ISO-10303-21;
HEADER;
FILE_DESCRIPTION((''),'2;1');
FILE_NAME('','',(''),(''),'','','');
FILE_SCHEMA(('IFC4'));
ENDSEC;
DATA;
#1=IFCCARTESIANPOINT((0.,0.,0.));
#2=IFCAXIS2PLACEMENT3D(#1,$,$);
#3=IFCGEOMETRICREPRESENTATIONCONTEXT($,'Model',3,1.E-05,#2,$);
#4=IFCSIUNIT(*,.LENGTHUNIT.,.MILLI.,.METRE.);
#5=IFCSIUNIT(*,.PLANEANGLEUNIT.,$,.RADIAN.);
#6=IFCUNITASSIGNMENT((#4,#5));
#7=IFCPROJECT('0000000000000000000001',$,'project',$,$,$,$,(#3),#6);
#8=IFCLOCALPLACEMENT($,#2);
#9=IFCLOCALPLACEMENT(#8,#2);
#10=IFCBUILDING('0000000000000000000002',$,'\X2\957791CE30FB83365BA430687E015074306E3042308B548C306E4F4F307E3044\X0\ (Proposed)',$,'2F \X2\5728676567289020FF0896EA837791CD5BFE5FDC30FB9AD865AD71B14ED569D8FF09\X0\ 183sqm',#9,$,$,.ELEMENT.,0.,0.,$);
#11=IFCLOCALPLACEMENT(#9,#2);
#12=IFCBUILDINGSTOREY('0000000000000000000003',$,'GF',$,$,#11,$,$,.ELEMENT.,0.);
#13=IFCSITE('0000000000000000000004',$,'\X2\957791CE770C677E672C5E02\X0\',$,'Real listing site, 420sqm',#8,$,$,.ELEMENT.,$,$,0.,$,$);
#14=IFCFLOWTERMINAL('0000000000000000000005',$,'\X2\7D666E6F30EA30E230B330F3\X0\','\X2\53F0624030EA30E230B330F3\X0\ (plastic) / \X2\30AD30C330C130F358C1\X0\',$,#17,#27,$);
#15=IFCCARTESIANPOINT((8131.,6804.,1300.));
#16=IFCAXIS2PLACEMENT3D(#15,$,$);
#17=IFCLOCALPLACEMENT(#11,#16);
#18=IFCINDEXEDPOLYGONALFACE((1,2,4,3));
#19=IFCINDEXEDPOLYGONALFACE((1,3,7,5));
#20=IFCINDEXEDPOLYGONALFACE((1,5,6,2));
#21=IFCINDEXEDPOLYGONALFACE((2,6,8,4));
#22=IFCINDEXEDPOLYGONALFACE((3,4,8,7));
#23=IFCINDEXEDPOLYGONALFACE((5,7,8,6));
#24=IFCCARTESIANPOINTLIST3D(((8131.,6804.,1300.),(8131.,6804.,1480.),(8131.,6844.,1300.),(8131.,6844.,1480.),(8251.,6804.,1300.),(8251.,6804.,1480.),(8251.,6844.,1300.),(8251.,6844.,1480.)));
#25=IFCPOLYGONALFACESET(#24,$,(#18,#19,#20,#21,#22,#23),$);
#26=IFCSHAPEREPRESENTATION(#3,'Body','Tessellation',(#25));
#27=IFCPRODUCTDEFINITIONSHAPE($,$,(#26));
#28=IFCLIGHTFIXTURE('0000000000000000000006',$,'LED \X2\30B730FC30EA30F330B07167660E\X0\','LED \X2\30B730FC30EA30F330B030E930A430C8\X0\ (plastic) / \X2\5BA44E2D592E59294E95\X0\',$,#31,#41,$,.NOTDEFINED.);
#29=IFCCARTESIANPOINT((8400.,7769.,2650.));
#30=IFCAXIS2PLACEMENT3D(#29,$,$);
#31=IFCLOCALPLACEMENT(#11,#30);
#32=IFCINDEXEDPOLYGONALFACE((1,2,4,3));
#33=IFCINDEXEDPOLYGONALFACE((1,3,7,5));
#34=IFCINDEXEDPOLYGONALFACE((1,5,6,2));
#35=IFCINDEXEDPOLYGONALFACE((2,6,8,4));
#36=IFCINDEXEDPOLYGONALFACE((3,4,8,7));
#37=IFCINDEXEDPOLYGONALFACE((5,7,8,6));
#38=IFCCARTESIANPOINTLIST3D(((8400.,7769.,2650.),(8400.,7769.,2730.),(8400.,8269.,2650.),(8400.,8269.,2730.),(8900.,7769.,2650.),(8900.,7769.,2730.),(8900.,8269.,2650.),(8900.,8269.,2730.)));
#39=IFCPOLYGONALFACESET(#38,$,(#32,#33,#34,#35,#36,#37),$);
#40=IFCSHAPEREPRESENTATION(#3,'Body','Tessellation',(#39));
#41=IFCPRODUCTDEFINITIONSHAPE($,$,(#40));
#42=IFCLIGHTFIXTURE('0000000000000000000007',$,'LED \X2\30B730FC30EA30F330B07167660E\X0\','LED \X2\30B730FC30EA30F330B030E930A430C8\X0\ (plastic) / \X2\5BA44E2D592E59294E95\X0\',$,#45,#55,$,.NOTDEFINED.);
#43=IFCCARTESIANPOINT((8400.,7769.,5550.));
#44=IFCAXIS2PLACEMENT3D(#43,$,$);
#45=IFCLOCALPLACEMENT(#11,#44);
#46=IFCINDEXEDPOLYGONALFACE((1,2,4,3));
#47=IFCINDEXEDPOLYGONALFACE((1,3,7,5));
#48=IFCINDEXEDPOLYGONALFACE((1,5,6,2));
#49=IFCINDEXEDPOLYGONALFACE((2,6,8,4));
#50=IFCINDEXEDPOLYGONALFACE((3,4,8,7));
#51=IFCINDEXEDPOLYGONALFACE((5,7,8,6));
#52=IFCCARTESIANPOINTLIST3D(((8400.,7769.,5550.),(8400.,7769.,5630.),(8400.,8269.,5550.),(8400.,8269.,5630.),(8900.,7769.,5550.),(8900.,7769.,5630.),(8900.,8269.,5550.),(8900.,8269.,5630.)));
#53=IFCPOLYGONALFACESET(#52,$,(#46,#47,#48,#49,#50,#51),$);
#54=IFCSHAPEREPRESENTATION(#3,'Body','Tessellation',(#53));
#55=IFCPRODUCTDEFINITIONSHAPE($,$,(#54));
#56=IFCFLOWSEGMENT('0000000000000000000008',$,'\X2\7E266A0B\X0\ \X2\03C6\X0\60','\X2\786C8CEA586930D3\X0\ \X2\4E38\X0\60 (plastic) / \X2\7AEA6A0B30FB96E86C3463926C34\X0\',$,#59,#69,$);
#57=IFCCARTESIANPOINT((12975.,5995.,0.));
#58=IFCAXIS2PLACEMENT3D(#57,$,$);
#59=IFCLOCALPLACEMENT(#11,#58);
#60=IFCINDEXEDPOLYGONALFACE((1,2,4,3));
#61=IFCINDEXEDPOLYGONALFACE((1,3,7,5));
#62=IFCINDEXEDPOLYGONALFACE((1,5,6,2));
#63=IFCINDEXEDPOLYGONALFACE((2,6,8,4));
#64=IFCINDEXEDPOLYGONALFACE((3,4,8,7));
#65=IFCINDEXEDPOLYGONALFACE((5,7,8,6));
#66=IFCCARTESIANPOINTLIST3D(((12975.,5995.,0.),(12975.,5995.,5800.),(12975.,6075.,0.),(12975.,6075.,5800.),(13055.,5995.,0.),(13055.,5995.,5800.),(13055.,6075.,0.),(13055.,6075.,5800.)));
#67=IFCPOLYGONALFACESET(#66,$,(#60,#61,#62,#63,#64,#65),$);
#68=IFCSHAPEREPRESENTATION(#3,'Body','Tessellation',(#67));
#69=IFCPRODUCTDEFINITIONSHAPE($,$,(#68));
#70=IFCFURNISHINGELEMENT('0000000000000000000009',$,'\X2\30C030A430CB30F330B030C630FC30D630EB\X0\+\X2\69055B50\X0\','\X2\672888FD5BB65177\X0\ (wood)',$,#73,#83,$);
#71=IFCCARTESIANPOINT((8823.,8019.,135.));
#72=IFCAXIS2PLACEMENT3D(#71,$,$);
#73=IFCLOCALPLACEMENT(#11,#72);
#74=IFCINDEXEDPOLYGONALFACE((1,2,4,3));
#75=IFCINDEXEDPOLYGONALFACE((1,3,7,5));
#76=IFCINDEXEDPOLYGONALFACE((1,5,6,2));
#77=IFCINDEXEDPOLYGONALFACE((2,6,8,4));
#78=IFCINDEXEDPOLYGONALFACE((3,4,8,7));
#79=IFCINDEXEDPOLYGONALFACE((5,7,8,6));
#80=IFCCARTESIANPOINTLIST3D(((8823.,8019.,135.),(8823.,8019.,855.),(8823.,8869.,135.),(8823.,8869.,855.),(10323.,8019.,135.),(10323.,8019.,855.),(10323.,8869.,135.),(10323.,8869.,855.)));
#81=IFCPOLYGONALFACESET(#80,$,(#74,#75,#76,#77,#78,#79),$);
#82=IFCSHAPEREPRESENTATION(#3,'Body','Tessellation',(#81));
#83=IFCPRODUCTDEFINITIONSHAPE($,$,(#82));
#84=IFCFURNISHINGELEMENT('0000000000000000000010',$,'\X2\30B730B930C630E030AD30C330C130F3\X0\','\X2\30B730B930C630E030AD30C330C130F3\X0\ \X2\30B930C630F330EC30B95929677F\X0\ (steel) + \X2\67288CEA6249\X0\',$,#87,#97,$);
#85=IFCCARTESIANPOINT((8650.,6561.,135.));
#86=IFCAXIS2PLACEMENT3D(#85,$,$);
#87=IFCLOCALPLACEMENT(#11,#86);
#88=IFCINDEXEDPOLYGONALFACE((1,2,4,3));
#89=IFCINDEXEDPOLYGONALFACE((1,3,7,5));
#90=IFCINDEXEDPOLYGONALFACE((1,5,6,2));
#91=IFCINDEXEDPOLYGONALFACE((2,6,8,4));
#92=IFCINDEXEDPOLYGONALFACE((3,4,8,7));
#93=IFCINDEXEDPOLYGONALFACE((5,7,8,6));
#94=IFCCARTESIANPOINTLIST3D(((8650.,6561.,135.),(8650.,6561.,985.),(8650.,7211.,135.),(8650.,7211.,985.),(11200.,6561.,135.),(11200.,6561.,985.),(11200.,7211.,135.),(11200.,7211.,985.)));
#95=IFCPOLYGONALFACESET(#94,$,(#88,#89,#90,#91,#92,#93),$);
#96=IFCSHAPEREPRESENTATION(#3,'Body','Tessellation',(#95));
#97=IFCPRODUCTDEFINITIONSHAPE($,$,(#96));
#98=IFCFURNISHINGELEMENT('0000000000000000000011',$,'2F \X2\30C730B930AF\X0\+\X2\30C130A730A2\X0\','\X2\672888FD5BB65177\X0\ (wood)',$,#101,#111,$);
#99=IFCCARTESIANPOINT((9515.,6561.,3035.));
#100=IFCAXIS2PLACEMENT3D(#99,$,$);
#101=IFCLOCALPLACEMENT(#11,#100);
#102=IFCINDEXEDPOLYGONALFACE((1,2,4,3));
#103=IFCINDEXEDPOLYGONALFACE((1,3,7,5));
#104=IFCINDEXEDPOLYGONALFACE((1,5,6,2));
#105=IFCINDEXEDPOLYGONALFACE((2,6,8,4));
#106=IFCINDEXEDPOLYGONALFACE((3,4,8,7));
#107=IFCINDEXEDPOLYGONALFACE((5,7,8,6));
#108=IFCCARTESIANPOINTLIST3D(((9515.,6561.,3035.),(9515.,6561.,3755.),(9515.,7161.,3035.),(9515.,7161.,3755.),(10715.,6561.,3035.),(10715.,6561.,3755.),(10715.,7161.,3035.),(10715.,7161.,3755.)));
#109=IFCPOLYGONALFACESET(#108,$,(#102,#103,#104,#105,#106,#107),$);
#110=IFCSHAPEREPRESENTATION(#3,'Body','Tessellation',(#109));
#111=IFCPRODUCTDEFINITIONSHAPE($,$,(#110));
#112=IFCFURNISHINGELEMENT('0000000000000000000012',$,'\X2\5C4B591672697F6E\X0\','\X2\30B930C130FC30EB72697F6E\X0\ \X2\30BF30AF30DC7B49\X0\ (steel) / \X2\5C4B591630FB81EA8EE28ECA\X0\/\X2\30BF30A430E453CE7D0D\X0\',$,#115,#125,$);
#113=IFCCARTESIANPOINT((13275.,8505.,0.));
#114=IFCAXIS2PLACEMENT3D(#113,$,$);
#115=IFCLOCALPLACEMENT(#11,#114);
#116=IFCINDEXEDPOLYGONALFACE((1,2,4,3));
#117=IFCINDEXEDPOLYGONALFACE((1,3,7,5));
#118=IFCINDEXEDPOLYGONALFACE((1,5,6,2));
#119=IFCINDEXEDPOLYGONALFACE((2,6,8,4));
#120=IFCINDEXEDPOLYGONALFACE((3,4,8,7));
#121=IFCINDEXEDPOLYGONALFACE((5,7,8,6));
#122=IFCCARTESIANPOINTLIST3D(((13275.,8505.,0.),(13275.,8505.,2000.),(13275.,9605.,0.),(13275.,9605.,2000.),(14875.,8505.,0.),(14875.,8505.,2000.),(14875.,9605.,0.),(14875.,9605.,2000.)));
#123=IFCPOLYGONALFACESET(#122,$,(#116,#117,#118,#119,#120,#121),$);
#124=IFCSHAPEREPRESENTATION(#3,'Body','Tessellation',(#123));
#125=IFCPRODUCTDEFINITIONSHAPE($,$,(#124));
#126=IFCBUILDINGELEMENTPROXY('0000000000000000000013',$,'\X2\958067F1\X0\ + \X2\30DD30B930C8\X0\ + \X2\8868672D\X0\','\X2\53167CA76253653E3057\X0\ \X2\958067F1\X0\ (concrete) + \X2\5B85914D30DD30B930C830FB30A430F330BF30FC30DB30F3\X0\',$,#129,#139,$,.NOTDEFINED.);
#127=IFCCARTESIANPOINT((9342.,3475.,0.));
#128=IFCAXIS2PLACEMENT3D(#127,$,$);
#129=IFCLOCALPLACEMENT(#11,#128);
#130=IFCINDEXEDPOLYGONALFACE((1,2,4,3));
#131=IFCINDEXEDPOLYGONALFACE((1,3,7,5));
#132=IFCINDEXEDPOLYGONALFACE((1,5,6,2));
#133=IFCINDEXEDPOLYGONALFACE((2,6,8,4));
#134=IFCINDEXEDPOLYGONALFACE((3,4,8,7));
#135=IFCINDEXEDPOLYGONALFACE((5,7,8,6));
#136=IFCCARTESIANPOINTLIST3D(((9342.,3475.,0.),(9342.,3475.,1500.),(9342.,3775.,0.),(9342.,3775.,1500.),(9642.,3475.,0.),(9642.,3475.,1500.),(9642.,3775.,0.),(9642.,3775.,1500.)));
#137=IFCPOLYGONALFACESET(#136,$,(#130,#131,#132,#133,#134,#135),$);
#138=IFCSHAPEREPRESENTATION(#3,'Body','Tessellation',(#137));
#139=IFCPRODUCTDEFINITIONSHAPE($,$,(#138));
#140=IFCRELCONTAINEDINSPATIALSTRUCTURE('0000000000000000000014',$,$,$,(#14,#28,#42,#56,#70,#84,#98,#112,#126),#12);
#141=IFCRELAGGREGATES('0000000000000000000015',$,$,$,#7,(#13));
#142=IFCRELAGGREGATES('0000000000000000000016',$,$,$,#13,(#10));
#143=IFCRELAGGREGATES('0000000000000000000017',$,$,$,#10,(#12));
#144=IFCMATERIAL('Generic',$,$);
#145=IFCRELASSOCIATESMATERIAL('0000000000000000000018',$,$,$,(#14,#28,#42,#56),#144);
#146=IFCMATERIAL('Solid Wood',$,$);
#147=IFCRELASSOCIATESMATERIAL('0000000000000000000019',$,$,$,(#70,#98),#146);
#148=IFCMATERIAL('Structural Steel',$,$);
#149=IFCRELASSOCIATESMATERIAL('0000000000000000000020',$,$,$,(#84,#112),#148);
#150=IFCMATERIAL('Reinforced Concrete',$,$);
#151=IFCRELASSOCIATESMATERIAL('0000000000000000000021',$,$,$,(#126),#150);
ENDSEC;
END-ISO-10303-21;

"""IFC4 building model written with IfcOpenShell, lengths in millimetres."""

from ifc_helpers import new_model, si_unit, frame, frame_2d, origin, place, context, project, spatial, rectangle, extrude, material, element, save


model = new_model("IFC4")

# Units and contexts
model_context = context("Model", 3, precision=1e-05, world=origin())
ifc_project = project(units=[si_unit("LENGTHUNIT", "METRE", prefix="MILLI"), si_unit("PLANEANGLEUNIT", "RADIAN")], contexts=[model_context])

# Site, building, storey
site_placement = place(None, origin())
site = spatial("IfcSite", under=ifc_project, at=site_placement, Name="長野県松本市", ObjectType="Real listing site, 420sqm", CompositionType="ELEMENT", RefElevation=0.0)
building_placement = place(site_placement, origin())
building = spatial("IfcBuilding", under=site, at=building_placement, Name="長野・茶室と縁側のある和の住まい (Proposed)", ObjectType="2F 在来木造（雪荷重対応・高断熱仕様） 183sqm", CompositionType="ELEMENT", ElevationOfRefHeight=0.0, ElevationOfTerrain=0.0)
storey_placement = place(building_placement, origin())
storey = spatial("IfcBuildingStorey", under=building, at=storey_placement, Name="GF", CompositionType="ELEMENT", Elevation=0.0)

# Shared definitions
ifc_material_1 = material(Name="Solid Wood")

# Shared definitions
ifc_material_2 = material(Name="Reinforced Concrete")

# Shared definitions
ifc_material_3 = material(Name="Structural Steel")

# Flow terminal
ifc_material_4 = material(Name="Generic")
flow_terminal_1_placement = place(storey_placement, frame((8131.0, 6804.0, 1300.0)))
element("IfcFlowTerminal", 1, at=flow_terminal_1_placement, inside=storey, material=ifc_material_4, Name="給湯リモコン", Description="台所リモコン (plastic) / キッチン壁", context=model_context, shape_type="SweptSolid", body=[
    extrude(rectangle(XDim=120.0, YDim=40.0, at=frame_2d((60.0, 20.0))), frame((8131.0, 6804.0, 1300.0)), (0.0, 0.0, 1.0), 180.0),
])

# Light fixtures
light_fixture_1_placement = place(storey_placement, frame((8400.0, 7769.0, 2650.0)))
element("IfcLightFixture", 2, at=light_fixture_1_placement, inside=storey, material=ifc_material_4, Name="LED シーリング照明", Description="LED シーリングライト (plastic) / 室中央天井", PredefinedType="NOTDEFINED", context=model_context, shape_type="SweptSolid", body=[
    extrude(rectangle(XDim=500.0, YDim=500.0, at=frame_2d((250.0, 250.0))), frame((8400.0, 7769.0, 2650.0)), (0.0, 0.0, 1.0), 80.0),
])
light_fixture_2_placement = place(storey_placement, frame((8400.0, 7769.0, 5550.0)))
element("IfcLightFixture", 3, at=light_fixture_2_placement, inside=storey, material=ifc_material_4, Name="LED シーリング照明", Description="LED シーリングライト (plastic) / 室中央天井", PredefinedType="NOTDEFINED", context=model_context, shape_type="SweptSolid", body=[
    extrude(rectangle(XDim=500.0, YDim=500.0, at=frame_2d((250.0, 250.0))), frame((8400.0, 7769.0, 5550.0)), (0.0, 0.0, 1.0), 80.0),
])

# Flow segment
flow_segment_placement = place(storey_placement, frame((12975.0, 5995.0, 0.0)))
element("IfcFlowSegment", 4, at=flow_segment_placement, inside=storey, material=ifc_material_4, Name="縦樋 φ60", Description="硬質塩ビ 丸60 (plastic) / 竪樋・雨水排水", context=model_context, shape_type="SweptSolid", body=[
    extrude(rectangle(XDim=80.0, YDim=80.0, at=frame_2d((40.0, 40.0))), frame((12975.0, 5995.0, 0.0)), (0.0, 0.0, 1.0), 5800.0),
])

# Furnishing elements
furnishing_1_placement = place(storey_placement, frame((8823.0, 8019.0, 135.0)))
element("IfcFurnishingElement", 5, at=furnishing_1_placement, inside=storey, material=ifc_material_1, Name="ダイニングテーブル+椅子", Description="木製家具 (wood)", context=model_context, shape_type="SweptSolid", body=[
    extrude(rectangle(XDim=1500.0, YDim=850.0, at=frame_2d((750.0, 425.0))), frame((8823.0, 8019.0, 135.0)), (0.0, 0.0, 1.0), 720.0),
])
furnishing_2_placement = place(storey_placement, frame((8650.0, 6561.0, 135.0)))
element("IfcFurnishingElement", 6, at=furnishing_2_placement, inside=storey, material=ifc_material_3, Name="システムキッチン", Description="システムキッチン ステンレス天板 (steel) + 木質扉", context=model_context, shape_type="SweptSolid", body=[
    extrude(rectangle(XDim=2550.0, YDim=650.0, at=frame_2d((1275.0, 325.0))), frame((8650.0, 6561.0, 135.0)), (0.0, 0.0, 1.0), 850.0),
])
furnishing_3_placement = place(storey_placement, frame((9515.0, 6561.0, 3035.0)))
element("IfcFurnishingElement", 7, at=furnishing_3_placement, inside=storey, material=ifc_material_1, Name="2F デスク+チェア", Description="木製家具 (wood)", context=model_context, shape_type="SweptSolid", body=[
    extrude(rectangle(XDim=1200.0, YDim=600.0, at=frame_2d((600.0, 300.0))), frame((9515.0, 6561.0, 3035.0)), (0.0, 0.0, 1.0), 720.0),
])
furnishing_4_placement = place(storey_placement, frame((13275.0, 8505.0, 0.0)))
element("IfcFurnishingElement", 8, at=furnishing_4_placement, inside=storey, material=ifc_material_3, Name="屋外物置", Description="スチール物置 タクボ等 (steel) / 屋外・自転車/タイヤ収納", context=model_context, shape_type="SweptSolid", body=[
    extrude(rectangle(XDim=1600.0, YDim=1100.0, at=frame_2d((800.0, 550.0))), frame((13275.0, 8505.0, 0.0)), (0.0, 0.0, 1.0), 2000.0),
])

# Building element proxy
proxy_placement = place(storey_placement, frame((9342.0, 3475.0, 0.0)))
element("IfcBuildingElementProxy", 9, at=proxy_placement, inside=storey, material=ifc_material_2, Name="門柱 + ポスト + 表札", Description="化粧打放し 門柱 (concrete) + 宅配ポスト・インターホン", PredefinedType="NOTDEFINED", context=model_context, shape_type="SweptSolid", body=[
    extrude(rectangle(XDim=300.0, YDim=300.0, at=frame_2d((150.0, 150.0))), frame((9342.0, 3475.0, 0.0)), (0.0, 0.0, 1.0), 1500.0),
])

save(model, "model.ifc")
